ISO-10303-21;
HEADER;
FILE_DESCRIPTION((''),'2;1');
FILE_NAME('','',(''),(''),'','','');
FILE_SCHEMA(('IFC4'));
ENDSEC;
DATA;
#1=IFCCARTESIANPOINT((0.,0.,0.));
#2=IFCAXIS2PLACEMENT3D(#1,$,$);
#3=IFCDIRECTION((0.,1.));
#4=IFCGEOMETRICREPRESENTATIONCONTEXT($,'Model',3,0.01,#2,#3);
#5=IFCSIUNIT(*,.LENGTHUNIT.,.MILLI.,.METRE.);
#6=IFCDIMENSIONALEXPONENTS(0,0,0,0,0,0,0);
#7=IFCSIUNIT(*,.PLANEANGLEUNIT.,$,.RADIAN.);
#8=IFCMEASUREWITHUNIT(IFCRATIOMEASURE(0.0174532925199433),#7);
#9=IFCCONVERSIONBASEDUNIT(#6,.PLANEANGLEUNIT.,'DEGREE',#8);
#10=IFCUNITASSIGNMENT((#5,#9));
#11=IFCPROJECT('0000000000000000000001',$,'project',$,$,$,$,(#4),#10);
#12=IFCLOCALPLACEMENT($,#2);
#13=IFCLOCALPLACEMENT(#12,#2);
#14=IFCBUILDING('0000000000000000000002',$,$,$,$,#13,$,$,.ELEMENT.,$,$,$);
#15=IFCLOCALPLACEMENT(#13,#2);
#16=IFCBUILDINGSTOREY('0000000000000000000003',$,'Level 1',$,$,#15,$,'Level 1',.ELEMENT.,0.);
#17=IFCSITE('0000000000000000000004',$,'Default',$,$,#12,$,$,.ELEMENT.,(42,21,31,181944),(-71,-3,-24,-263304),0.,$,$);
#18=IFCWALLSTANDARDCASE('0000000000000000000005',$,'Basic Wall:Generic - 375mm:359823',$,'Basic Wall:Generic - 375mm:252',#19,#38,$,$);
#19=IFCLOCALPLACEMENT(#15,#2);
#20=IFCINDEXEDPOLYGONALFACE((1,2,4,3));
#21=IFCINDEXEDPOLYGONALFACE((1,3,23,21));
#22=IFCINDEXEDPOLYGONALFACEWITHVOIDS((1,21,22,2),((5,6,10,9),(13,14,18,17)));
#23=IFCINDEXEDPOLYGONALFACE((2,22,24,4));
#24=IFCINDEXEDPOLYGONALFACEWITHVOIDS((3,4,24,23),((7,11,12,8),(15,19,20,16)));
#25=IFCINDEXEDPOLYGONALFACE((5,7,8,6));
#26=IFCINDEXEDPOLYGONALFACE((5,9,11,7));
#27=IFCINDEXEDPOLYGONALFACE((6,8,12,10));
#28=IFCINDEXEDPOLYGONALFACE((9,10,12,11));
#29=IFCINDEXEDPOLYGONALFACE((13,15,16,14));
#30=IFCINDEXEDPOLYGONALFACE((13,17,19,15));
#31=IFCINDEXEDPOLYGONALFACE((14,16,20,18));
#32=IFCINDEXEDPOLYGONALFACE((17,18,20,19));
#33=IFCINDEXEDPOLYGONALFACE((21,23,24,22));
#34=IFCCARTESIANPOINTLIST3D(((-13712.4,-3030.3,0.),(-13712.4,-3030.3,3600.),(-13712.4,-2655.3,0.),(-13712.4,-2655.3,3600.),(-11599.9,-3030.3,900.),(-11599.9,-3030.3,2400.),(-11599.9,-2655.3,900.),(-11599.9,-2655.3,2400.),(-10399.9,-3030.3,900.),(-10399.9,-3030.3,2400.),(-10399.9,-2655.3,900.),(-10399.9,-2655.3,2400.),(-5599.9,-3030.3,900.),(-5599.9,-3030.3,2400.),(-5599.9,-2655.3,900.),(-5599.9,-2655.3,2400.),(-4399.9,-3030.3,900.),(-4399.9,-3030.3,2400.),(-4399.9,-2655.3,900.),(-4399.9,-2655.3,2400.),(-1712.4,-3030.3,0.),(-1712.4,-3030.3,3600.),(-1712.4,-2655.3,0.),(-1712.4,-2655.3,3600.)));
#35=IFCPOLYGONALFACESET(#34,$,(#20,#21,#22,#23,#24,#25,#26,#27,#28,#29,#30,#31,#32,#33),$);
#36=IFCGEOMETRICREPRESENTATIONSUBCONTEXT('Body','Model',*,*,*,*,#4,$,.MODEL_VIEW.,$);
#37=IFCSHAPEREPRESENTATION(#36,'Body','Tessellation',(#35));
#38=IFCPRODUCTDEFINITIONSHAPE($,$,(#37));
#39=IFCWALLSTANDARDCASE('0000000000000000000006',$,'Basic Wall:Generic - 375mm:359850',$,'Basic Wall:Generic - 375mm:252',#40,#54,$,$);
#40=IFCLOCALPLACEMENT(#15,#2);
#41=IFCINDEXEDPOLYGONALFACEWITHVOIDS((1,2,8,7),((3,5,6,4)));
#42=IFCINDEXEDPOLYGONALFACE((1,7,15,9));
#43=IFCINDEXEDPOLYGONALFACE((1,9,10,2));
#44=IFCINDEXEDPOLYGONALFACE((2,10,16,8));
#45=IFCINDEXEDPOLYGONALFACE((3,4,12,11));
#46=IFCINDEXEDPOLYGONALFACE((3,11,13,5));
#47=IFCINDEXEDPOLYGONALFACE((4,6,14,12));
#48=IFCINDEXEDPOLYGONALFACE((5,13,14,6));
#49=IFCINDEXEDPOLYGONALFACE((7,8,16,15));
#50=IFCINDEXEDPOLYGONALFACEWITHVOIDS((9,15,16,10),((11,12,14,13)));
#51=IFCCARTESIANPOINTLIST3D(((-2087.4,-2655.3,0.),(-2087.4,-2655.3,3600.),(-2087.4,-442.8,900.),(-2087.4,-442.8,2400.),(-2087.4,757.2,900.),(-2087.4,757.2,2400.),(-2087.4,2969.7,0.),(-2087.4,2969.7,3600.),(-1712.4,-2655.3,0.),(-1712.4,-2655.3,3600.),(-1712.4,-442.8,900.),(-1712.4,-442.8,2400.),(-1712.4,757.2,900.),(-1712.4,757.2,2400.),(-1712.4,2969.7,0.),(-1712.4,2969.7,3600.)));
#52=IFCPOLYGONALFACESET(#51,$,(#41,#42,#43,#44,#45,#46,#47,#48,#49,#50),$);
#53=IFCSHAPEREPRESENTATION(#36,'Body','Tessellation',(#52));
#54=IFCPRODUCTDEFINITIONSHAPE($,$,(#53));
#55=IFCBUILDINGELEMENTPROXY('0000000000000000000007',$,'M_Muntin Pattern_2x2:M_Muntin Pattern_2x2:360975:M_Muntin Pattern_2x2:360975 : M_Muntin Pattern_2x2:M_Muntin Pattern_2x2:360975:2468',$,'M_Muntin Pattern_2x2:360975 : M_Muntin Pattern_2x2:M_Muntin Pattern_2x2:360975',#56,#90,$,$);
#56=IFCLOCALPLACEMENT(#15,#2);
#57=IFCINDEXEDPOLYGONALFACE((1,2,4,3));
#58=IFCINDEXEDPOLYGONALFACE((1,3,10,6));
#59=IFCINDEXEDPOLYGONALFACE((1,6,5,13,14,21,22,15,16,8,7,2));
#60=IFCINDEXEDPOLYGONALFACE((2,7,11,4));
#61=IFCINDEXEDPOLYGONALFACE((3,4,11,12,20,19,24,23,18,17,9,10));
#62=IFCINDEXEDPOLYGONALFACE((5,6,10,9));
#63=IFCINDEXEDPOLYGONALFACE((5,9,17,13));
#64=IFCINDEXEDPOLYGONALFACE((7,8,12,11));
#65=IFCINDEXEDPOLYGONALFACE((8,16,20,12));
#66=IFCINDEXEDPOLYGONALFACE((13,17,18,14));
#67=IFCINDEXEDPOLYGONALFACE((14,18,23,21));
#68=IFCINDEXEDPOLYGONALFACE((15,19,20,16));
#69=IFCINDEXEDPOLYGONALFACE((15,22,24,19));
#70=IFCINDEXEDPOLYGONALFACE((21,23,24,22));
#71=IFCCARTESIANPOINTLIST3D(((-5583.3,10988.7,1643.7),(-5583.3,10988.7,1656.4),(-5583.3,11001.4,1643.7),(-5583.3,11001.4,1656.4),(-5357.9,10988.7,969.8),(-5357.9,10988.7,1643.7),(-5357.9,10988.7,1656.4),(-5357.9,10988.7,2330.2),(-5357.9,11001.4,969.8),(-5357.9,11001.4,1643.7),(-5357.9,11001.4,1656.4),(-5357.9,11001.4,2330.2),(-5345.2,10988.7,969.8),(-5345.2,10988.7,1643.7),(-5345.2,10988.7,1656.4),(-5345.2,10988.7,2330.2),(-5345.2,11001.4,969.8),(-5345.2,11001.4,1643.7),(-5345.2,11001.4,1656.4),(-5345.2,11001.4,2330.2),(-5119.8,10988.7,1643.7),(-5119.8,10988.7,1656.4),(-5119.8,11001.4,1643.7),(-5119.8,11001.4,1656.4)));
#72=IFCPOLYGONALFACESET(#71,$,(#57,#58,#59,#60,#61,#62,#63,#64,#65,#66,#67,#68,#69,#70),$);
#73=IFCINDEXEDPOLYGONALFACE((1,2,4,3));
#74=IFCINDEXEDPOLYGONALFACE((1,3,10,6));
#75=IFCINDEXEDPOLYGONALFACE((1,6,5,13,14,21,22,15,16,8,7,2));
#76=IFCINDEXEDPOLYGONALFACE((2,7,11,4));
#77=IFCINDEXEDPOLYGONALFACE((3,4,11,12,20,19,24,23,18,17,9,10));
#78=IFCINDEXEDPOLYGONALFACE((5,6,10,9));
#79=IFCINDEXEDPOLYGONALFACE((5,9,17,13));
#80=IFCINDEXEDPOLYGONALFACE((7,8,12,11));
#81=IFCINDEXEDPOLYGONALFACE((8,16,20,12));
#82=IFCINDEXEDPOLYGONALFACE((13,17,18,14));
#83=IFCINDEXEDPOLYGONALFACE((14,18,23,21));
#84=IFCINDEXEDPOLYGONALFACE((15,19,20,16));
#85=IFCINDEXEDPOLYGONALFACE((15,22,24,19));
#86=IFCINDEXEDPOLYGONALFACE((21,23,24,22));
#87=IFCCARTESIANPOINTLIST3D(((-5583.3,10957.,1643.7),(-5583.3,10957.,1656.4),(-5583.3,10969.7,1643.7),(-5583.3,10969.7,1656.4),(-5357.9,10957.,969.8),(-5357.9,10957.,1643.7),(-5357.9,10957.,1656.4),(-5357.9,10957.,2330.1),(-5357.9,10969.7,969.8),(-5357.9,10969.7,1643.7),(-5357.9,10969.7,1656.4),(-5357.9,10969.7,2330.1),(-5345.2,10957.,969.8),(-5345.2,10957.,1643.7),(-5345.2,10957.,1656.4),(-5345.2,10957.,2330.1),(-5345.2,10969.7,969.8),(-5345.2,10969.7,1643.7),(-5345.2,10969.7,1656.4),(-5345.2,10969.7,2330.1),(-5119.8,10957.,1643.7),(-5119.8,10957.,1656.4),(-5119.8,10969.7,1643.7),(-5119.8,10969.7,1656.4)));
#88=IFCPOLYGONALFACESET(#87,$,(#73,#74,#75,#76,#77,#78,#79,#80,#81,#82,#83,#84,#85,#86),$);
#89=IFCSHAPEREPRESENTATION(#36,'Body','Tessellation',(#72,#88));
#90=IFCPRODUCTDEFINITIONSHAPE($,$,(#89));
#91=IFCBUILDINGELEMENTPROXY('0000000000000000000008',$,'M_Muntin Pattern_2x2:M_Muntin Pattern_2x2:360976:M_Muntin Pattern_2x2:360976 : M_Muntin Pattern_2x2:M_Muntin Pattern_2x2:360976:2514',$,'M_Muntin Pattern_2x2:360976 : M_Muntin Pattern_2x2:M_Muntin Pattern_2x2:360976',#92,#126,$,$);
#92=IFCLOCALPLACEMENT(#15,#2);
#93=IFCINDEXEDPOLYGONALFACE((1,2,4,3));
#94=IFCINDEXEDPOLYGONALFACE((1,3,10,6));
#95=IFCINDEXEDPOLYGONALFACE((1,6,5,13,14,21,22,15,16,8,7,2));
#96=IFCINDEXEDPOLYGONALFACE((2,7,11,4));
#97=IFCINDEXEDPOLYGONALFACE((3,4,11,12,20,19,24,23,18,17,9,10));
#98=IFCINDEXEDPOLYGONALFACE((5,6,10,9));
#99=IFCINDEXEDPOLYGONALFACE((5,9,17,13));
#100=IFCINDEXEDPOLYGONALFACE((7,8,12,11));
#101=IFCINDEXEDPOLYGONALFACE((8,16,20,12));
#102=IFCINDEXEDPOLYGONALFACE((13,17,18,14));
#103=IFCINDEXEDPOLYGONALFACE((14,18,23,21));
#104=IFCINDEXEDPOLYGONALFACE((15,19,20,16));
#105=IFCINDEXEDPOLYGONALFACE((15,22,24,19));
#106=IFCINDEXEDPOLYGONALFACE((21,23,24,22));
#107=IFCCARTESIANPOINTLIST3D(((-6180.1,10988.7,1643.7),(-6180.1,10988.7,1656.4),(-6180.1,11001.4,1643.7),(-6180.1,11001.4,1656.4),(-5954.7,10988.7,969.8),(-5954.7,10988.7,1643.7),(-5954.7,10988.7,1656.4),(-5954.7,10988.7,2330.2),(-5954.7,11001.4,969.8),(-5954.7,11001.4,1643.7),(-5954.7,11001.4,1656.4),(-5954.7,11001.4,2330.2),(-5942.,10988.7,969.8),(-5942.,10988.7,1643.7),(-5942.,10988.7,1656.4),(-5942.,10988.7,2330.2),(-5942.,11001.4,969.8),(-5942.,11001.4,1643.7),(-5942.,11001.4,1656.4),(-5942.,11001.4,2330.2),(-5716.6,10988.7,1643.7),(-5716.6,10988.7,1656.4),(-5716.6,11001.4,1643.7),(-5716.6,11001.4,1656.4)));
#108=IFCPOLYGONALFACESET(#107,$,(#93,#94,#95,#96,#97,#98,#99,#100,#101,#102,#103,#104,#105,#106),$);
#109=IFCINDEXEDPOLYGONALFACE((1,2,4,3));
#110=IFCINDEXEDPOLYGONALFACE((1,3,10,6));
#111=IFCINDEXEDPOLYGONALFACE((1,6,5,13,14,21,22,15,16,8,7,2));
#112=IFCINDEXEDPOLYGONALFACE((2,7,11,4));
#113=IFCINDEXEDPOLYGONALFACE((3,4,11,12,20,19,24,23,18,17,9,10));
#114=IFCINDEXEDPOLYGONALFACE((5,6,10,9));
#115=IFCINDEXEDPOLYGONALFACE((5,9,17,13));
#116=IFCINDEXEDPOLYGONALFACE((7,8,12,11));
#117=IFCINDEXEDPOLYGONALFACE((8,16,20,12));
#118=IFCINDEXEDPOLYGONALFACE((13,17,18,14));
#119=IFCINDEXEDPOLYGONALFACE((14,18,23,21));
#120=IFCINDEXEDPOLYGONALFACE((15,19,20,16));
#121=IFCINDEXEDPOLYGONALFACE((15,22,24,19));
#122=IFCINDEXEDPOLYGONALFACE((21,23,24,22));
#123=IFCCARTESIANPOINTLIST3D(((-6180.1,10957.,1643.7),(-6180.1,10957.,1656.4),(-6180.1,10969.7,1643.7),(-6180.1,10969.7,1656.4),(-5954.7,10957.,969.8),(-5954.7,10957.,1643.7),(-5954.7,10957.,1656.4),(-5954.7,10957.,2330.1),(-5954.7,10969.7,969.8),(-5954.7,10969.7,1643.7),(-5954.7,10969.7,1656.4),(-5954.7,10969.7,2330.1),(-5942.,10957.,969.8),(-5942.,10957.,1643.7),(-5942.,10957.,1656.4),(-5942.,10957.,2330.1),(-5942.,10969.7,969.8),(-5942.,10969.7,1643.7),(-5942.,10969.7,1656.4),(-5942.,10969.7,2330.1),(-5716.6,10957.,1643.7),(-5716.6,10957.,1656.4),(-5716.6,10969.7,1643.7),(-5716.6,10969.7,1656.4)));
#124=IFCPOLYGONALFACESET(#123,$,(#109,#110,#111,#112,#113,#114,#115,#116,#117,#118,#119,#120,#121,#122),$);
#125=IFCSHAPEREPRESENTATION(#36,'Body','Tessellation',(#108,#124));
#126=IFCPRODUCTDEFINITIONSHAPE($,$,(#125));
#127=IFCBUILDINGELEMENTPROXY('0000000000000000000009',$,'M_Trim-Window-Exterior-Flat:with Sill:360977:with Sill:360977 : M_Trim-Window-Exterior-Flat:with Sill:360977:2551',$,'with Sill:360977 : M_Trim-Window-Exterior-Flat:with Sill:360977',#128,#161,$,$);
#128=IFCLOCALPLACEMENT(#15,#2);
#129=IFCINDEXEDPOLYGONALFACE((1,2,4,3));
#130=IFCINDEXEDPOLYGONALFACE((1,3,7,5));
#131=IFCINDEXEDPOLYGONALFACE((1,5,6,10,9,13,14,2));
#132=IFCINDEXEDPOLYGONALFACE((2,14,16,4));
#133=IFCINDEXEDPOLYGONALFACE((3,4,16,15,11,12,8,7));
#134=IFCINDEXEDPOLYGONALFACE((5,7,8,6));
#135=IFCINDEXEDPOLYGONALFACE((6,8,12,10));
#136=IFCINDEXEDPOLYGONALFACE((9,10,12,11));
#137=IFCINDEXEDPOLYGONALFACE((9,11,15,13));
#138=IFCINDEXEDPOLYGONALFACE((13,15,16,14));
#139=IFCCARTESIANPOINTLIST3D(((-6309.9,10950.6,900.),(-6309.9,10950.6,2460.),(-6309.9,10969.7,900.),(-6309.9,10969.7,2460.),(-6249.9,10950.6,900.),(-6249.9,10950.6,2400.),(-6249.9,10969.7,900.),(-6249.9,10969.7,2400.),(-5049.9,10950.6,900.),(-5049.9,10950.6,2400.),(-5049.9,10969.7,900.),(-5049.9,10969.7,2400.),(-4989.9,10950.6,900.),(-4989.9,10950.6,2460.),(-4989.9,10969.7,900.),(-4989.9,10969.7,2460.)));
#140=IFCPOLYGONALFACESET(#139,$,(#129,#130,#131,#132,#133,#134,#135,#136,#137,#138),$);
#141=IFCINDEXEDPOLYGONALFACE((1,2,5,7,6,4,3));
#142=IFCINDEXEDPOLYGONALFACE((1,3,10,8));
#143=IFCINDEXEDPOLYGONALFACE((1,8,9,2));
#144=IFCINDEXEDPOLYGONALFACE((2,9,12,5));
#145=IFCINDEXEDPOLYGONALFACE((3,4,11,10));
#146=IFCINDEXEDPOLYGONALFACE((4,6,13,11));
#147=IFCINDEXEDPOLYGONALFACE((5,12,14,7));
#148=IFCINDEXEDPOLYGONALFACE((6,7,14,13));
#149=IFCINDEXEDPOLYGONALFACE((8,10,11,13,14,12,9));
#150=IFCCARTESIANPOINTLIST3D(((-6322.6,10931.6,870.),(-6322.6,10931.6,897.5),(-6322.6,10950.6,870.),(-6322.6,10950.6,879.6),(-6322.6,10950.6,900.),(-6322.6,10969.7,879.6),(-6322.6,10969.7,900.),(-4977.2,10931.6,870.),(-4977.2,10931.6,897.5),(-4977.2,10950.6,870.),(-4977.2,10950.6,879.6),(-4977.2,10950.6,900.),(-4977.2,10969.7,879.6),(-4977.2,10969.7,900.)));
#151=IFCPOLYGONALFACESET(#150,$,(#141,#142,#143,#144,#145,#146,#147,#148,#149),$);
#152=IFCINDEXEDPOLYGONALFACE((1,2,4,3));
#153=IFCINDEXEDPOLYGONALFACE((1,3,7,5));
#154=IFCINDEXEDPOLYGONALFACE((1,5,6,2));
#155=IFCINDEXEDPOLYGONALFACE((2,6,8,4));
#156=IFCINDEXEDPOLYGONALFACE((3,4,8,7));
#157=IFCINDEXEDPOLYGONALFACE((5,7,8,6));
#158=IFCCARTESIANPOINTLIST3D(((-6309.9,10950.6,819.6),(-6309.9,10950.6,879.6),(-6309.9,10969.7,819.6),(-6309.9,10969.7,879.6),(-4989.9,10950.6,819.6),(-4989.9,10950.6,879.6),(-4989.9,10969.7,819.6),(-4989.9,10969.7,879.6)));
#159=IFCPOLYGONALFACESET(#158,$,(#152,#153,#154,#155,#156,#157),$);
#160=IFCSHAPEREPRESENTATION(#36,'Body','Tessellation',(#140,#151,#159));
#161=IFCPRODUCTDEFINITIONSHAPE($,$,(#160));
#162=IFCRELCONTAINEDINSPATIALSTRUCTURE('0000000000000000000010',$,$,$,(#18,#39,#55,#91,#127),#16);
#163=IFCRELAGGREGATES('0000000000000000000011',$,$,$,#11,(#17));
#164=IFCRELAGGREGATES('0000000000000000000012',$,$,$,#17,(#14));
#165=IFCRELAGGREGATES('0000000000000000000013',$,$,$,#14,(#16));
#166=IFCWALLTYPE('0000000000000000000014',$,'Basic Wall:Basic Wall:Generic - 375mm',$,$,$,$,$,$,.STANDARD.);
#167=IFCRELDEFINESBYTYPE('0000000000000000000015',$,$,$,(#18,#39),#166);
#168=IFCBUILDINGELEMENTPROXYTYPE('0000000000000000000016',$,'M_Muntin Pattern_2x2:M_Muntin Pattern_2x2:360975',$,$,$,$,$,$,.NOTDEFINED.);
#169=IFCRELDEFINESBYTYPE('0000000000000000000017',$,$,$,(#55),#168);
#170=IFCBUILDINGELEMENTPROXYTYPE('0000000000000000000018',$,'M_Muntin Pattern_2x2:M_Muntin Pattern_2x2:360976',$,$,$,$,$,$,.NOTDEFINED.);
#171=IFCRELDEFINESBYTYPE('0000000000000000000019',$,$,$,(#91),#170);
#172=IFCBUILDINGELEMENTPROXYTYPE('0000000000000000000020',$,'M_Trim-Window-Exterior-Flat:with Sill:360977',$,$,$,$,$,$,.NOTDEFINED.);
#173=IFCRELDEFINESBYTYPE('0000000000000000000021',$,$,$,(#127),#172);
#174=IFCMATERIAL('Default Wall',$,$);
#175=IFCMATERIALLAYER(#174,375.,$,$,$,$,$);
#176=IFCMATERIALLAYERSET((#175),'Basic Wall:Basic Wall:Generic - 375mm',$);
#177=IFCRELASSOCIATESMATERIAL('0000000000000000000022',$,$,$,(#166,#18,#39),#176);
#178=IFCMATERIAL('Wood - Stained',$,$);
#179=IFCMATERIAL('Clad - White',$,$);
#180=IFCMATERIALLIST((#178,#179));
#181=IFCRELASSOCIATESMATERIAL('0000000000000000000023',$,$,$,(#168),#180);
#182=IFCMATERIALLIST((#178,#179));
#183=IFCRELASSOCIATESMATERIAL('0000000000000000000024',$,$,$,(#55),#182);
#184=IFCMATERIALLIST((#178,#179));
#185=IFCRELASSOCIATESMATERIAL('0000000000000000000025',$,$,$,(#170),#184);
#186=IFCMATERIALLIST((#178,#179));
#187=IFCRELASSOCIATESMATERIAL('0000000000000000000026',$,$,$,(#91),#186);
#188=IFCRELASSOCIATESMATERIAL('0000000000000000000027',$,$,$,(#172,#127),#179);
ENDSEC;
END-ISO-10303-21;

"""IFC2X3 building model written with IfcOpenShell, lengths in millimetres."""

from ifc_helpers import new_model, entity, si_unit, converted_unit, direction, frame, frame_2d, origin, place, context, subcontext, project, spatial, polyline, rectangle, outline, extrude, source, transform, mapped, material, material_list, layer, layer_set, layer_usage, type_object, type_shapes, element, save


model = new_model("IFC2X3")

# Units and contexts
model_context = context("Model", 3, precision=0.01, world=origin(), true_north=direction((0.0, 1.0)))
body_context = subcontext(model_context, "Body", "Model", "MODEL_VIEW")
ifc_project = project(units=[si_unit("LENGTHUNIT", "METRE", prefix="MILLI"), converted_unit("PLANEANGLEUNIT", "DEGREE", entity("IfcRatioMeasure", 0.0174532925199433), si_unit("PLANEANGLEUNIT", "RADIAN"), dimensions=[0, 0, 0, 0, 0, 0, 0])], contexts=[model_context])

# Site, building, storey
site_placement = place(None, origin())
site = spatial("IfcSite", under=ifc_project, at=site_placement, Name="Default", CompositionType="ELEMENT", RefLatitude=(42, 21, 31, 181944), RefLongitude=(-71, -3, -24, -263304), RefElevation=0.0)
building_placement = place(site_placement, origin())
building = spatial("IfcBuilding", under=site, at=building_placement, CompositionType="ELEMENT")
storey_placement = place(building_placement, origin())
storey = spatial("IfcBuildingStorey", under=building, at=storey_placement, Name="Level 1", LongName="Level 1", CompositionType="ELEMENT", Elevation=0.0)

# Wall, openings
ifc_material_1 = material(Name="Default Wall")
ifc_layer = layer(ifc_material_1, 375.0)
ifc_layer_set = layer_set([ifc_layer], Name="Basic Wall:Basic Wall:Generic - 375mm")
ifc_layer_usage_1 = layer_usage(ifc_layer_set, "AXIS2", "NEGATIVE", 187.5)
wall_type = type_object("IfcWallType", Name="Basic Wall:Basic Wall:Generic - 375mm", PredefinedType="STANDARD", material=ifc_layer_set)
wall_1_placement = place(storey_placement, frame((-13712.4, -2842.8, 0.0)))
wall_1 = element("IfcWallStandardCase", 1, at=wall_1_placement, inside=storey, type_object=wall_type, material=ifc_layer_usage_1, Name="Basic Wall:Generic - 375mm:359823", ObjectType="Basic Wall:Generic - 375mm:252", context=body_context, shape_type="SweptSolid", body=[
    extrude(rectangle(XDim=12000.0, YDim=375.0, at=frame_2d((6000.0, 0.0), x_axis=(-1.0, 0.0))), origin(), (0.0, 0.0, 1.0), 3600.0),
])
opening_1_placement = place(wall_1_placement, frame((13712.4, 2842.8, 0.0)))
element("IfcOpeningElement", 2, at=opening_1_placement, cuts=wall_1, ObjectType="Opening", context=body_context, shape_type="SweptSolid", body=[
    extrude(rectangle(XDim=1500.0, YDim=1200.0, at=frame_2d((0.0, 0.0), x_axis=(0.0, 1.0))), frame((-10999.9, -3034.1, 1650.0), z_axis=(0.0, 1.0, 0.0), x_axis=(-1.0, 0.0, 0.0)), (0.0, 0.0, 1.0), 382.5),
])
opening_2_placement = place(wall_1_placement, frame((13712.4, 2842.8, 0.0)))
element("IfcOpeningElement", 3, at=opening_2_placement, cuts=wall_1, ObjectType="Opening", context=body_context, shape_type="SweptSolid", body=[
    extrude(rectangle(XDim=1500.0, YDim=1200.0, at=frame_2d((0.0, 0.0), x_axis=(0.0, 1.0))), frame((-4999.9, -3034.1, 1650.0), z_axis=(0.0, 1.0, 0.0), x_axis=(-1.0, 0.0, 0.0)), (0.0, 0.0, 1.0), 382.5),
])

# Wall, opening
ifc_layer_usage_2 = layer_usage(ifc_layer_set, "AXIS2", "NEGATIVE", 187.5)
wall_2_placement = place(storey_placement, frame((-1899.9, -2655.3, 0.0), z_axis=(0.0, 0.0, 1.0), x_axis=(0.0, 1.0, 0.0)))
wall_2 = element("IfcWallStandardCase", 4, at=wall_2_placement, inside=storey, type_object=wall_type, material=ifc_layer_usage_2, Name="Basic Wall:Generic - 375mm:359850", ObjectType="Basic Wall:Generic - 375mm:252", context=body_context, shape_type="SweptSolid", body=[
    extrude(rectangle(XDim=5625.0, YDim=375.0, at=frame_2d((2812.5, 0.0), x_axis=(-1.0, 0.0))), origin(), (0.0, 0.0, 1.0), 3600.0),
])
opening_3_placement = place(wall_2_placement, frame((2655.3, -1899.9, 0.0), z_axis=(0.0, 0.0, 1.0), x_axis=(0.0, -1.0, 0.0)))
element("IfcOpeningElement", 5, at=opening_3_placement, cuts=wall_2, ObjectType="Opening", context=body_context, shape_type="SweptSolid", body=[
    extrude(rectangle(XDim=1500.0, YDim=1200.0, at=frame_2d((0.0, 0.0), x_axis=(0.0, 1.0))), frame((-1708.7, 157.2, 1650.0), z_axis=(-1.0, 0.0, 0.0), x_axis=(0.0, -1.0, 0.0)), (0.0, 0.0, 1.0), 382.5),
])

# Building element proxies
ifc_material_2 = material(Name="Wood - Stained")
ifc_material_3 = material(Name="Clad - White")
ifc_material_list_1 = material_list([ifc_material_2, ifc_material_3])
ifc_material_list_2 = material_list([ifc_material_2, ifc_material_3])
building_element_proxy_type_1 = type_object("IfcBuildingElementProxyType", Name="M_Muntin Pattern_2x2:M_Muntin Pattern_2x2:360975", PredefinedType="NOTDEFINED", material=ifc_material_list_2)
shared_shape_1 = source(origin(), body_context, "Body", "SweptSolid", [
    extrude(outline(polyline([(-680.2, 6.4), (-680.2, -6.3), (-6.4, -6.3), (-6.4, -231.7), (6.3, -231.7), (6.3, -6.3), (680.2, -6.3), (680.2, 6.4), (6.3, 6.4), (6.3, 231.7), (-6.4, 231.7), (-6.4, 6.4), (-680.2, 6.4)])), frame((-5351.5, 10988.7, 1650.0), z_axis=(0.0, -1.0, 0.0), x_axis=(0.0, 0.0, -1.0)), (0.0, 0.0, -1.0), 12.7),
    extrude(outline(polyline([(-680.1, 6.4), (-680.1, -6.3), (-6.4, -6.3), (-6.4, -231.7), (6.3, -231.7), (6.3, -6.3), (680.2, -6.3), (680.2, 6.4), (6.3, 6.4), (6.3, 231.7), (-6.4, 231.7), (-6.4, 6.4), (-680.1, 6.4)])), frame((-5351.5, 10957.0, 1650.0), z_axis=(0.0, -1.0, 0.0), x_axis=(0.0, 0.0, -1.0)), (0.0, 0.0, -1.0), 12.7),
])
type_shapes(building_element_proxy_type_1, [shared_shape_1])
proxy_1_placement = place(storey_placement, origin())
element("IfcBuildingElementProxy", 6, at=proxy_1_placement, inside=storey, type_object=building_element_proxy_type_1, material=ifc_material_list_1, Name="M_Muntin Pattern_2x2:M_Muntin Pattern_2x2:360975:M_Muntin Pattern_2x2:360975 : M_Muntin Pattern_2x2:M_Muntin Pattern_2x2:360975:2468", ObjectType="M_Muntin Pattern_2x2:360975 : M_Muntin Pattern_2x2:M_Muntin Pattern_2x2:360975", context=body_context, shape_type="MappedRepresentation", body=[
    mapped(shared_shape_1, transform((0.0, 0.0, 0.0), scale=1.0)),
])
ifc_material_list_3 = material_list([ifc_material_2, ifc_material_3])
ifc_material_list_4 = material_list([ifc_material_2, ifc_material_3])
building_element_proxy_type_2 = type_object("IfcBuildingElementProxyType", Name="M_Muntin Pattern_2x2:M_Muntin Pattern_2x2:360976", PredefinedType="NOTDEFINED", material=ifc_material_list_4)
shared_shape_2 = source(origin(), body_context, "Body", "SweptSolid", [
    extrude(outline(polyline([(-6.4, -680.1), (6.3, -680.1), (6.3, -6.4), (231.7, -6.4), (231.7, 6.3), (6.3, 6.3), (6.3, 680.2), (-6.4, 680.2), (-6.4, 6.3), (-231.7, 6.3), (-231.7, -6.4), (-6.4, -6.4), (-6.4, -680.1)])), frame((-5948.4, 10988.7, 1650.0), z_axis=(0.0, 1.0, 0.0), x_axis=(1.0, 0.0, 0.0)), (0.0, 0.0, 1.0), 12.7),
    extrude(outline(polyline([(-6.4, -680.1), (6.3, -680.1), (6.3, -6.4), (231.7, -6.4), (231.7, 6.3), (6.3, 6.3), (6.3, 680.2), (-6.4, 680.2), (-6.4, 6.3), (-231.7, 6.3), (-231.7, -6.4), (-6.4, -6.4), (-6.4, -680.1)])), frame((-5948.4, 10957.0, 1650.0), z_axis=(0.0, 1.0, 0.0), x_axis=(1.0, 0.0, 0.0)), (0.0, 0.0, 1.0), 12.7),
])
type_shapes(building_element_proxy_type_2, [shared_shape_2])
proxy_2_placement = place(storey_placement, origin())
element("IfcBuildingElementProxy", 7, at=proxy_2_placement, inside=storey, type_object=building_element_proxy_type_2, material=ifc_material_list_3, Name="M_Muntin Pattern_2x2:M_Muntin Pattern_2x2:360976:M_Muntin Pattern_2x2:360976 : M_Muntin Pattern_2x2:M_Muntin Pattern_2x2:360976:2514", ObjectType="M_Muntin Pattern_2x2:360976 : M_Muntin Pattern_2x2:M_Muntin Pattern_2x2:360976", context=body_context, shape_type="MappedRepresentation", body=[
    mapped(shared_shape_2, transform((0.0, 0.0, 0.0), scale=1.0)),
])
building_element_proxy_type_3 = type_object("IfcBuildingElementProxyType", Name="M_Trim-Window-Exterior-Flat:with Sill:360977", PredefinedType="NOTDEFINED", material=ifc_material_3)
shared_shape_3 = source(origin(), body_context, "Body", "SweptSolid", [
    extrude(outline(polyline([(-765.0, -660.0), (795.0, -660.0), (795.0, 660.0), (-765.0, 660.0), (-765.0, 600.0), (735.0, 600.0), (735.0, -600.0), (-765.0, -600.0), (-765.0, -660.0)])), frame((-5649.9, 10950.6, 1665.0), z_axis=(0.0, 1.0, 0.0), x_axis=(0.0, 0.0, 1.0)), (0.0, 0.0, 1.0), 19.1),
    extrude(outline(polyline([(-15.2, 0.0), (-15.2, -19.0), (12.3, -19.0), (14.8, 0.0), (14.8, 19.0), (-5.7, 19.0), (-5.7, 0.0), (-15.2, 0.0)])), frame((-6322.6, 10950.6, 885.2), z_axis=(-1.0, 0.0, 0.0), x_axis=(0.0, 0.0, 1.0)), (0.0, 0.0, -1.0), 1345.4),
    extrude(rectangle(XDim=19.1, YDim=1320.0, at=frame_2d((0.0, 0.0), x_axis=(1.0, 0.0))), frame((-5649.9, 10960.1, 819.6), z_axis=(0.0, 0.0, 1.0), x_axis=(0.0, 1.0, 0.0)), (0.0, 0.0, 1.0), 60.0),
])
type_shapes(building_element_proxy_type_3, [shared_shape_3])
proxy_3_placement = place(storey_placement, origin())
element("IfcBuildingElementProxy", 8, at=proxy_3_placement, inside=storey, type_object=building_element_proxy_type_3, material=ifc_material_3, Name="M_Trim-Window-Exterior-Flat:with Sill:360977:with Sill:360977 : M_Trim-Window-Exterior-Flat:with Sill:360977:2551", ObjectType="with Sill:360977 : M_Trim-Window-Exterior-Flat:with Sill:360977", context=body_context, shape_type="MappedRepresentation", body=[
    mapped(shared_shape_3, transform((0.0, 0.0, 0.0), scale=1.0)),
])

save(model, "model.ifc")
